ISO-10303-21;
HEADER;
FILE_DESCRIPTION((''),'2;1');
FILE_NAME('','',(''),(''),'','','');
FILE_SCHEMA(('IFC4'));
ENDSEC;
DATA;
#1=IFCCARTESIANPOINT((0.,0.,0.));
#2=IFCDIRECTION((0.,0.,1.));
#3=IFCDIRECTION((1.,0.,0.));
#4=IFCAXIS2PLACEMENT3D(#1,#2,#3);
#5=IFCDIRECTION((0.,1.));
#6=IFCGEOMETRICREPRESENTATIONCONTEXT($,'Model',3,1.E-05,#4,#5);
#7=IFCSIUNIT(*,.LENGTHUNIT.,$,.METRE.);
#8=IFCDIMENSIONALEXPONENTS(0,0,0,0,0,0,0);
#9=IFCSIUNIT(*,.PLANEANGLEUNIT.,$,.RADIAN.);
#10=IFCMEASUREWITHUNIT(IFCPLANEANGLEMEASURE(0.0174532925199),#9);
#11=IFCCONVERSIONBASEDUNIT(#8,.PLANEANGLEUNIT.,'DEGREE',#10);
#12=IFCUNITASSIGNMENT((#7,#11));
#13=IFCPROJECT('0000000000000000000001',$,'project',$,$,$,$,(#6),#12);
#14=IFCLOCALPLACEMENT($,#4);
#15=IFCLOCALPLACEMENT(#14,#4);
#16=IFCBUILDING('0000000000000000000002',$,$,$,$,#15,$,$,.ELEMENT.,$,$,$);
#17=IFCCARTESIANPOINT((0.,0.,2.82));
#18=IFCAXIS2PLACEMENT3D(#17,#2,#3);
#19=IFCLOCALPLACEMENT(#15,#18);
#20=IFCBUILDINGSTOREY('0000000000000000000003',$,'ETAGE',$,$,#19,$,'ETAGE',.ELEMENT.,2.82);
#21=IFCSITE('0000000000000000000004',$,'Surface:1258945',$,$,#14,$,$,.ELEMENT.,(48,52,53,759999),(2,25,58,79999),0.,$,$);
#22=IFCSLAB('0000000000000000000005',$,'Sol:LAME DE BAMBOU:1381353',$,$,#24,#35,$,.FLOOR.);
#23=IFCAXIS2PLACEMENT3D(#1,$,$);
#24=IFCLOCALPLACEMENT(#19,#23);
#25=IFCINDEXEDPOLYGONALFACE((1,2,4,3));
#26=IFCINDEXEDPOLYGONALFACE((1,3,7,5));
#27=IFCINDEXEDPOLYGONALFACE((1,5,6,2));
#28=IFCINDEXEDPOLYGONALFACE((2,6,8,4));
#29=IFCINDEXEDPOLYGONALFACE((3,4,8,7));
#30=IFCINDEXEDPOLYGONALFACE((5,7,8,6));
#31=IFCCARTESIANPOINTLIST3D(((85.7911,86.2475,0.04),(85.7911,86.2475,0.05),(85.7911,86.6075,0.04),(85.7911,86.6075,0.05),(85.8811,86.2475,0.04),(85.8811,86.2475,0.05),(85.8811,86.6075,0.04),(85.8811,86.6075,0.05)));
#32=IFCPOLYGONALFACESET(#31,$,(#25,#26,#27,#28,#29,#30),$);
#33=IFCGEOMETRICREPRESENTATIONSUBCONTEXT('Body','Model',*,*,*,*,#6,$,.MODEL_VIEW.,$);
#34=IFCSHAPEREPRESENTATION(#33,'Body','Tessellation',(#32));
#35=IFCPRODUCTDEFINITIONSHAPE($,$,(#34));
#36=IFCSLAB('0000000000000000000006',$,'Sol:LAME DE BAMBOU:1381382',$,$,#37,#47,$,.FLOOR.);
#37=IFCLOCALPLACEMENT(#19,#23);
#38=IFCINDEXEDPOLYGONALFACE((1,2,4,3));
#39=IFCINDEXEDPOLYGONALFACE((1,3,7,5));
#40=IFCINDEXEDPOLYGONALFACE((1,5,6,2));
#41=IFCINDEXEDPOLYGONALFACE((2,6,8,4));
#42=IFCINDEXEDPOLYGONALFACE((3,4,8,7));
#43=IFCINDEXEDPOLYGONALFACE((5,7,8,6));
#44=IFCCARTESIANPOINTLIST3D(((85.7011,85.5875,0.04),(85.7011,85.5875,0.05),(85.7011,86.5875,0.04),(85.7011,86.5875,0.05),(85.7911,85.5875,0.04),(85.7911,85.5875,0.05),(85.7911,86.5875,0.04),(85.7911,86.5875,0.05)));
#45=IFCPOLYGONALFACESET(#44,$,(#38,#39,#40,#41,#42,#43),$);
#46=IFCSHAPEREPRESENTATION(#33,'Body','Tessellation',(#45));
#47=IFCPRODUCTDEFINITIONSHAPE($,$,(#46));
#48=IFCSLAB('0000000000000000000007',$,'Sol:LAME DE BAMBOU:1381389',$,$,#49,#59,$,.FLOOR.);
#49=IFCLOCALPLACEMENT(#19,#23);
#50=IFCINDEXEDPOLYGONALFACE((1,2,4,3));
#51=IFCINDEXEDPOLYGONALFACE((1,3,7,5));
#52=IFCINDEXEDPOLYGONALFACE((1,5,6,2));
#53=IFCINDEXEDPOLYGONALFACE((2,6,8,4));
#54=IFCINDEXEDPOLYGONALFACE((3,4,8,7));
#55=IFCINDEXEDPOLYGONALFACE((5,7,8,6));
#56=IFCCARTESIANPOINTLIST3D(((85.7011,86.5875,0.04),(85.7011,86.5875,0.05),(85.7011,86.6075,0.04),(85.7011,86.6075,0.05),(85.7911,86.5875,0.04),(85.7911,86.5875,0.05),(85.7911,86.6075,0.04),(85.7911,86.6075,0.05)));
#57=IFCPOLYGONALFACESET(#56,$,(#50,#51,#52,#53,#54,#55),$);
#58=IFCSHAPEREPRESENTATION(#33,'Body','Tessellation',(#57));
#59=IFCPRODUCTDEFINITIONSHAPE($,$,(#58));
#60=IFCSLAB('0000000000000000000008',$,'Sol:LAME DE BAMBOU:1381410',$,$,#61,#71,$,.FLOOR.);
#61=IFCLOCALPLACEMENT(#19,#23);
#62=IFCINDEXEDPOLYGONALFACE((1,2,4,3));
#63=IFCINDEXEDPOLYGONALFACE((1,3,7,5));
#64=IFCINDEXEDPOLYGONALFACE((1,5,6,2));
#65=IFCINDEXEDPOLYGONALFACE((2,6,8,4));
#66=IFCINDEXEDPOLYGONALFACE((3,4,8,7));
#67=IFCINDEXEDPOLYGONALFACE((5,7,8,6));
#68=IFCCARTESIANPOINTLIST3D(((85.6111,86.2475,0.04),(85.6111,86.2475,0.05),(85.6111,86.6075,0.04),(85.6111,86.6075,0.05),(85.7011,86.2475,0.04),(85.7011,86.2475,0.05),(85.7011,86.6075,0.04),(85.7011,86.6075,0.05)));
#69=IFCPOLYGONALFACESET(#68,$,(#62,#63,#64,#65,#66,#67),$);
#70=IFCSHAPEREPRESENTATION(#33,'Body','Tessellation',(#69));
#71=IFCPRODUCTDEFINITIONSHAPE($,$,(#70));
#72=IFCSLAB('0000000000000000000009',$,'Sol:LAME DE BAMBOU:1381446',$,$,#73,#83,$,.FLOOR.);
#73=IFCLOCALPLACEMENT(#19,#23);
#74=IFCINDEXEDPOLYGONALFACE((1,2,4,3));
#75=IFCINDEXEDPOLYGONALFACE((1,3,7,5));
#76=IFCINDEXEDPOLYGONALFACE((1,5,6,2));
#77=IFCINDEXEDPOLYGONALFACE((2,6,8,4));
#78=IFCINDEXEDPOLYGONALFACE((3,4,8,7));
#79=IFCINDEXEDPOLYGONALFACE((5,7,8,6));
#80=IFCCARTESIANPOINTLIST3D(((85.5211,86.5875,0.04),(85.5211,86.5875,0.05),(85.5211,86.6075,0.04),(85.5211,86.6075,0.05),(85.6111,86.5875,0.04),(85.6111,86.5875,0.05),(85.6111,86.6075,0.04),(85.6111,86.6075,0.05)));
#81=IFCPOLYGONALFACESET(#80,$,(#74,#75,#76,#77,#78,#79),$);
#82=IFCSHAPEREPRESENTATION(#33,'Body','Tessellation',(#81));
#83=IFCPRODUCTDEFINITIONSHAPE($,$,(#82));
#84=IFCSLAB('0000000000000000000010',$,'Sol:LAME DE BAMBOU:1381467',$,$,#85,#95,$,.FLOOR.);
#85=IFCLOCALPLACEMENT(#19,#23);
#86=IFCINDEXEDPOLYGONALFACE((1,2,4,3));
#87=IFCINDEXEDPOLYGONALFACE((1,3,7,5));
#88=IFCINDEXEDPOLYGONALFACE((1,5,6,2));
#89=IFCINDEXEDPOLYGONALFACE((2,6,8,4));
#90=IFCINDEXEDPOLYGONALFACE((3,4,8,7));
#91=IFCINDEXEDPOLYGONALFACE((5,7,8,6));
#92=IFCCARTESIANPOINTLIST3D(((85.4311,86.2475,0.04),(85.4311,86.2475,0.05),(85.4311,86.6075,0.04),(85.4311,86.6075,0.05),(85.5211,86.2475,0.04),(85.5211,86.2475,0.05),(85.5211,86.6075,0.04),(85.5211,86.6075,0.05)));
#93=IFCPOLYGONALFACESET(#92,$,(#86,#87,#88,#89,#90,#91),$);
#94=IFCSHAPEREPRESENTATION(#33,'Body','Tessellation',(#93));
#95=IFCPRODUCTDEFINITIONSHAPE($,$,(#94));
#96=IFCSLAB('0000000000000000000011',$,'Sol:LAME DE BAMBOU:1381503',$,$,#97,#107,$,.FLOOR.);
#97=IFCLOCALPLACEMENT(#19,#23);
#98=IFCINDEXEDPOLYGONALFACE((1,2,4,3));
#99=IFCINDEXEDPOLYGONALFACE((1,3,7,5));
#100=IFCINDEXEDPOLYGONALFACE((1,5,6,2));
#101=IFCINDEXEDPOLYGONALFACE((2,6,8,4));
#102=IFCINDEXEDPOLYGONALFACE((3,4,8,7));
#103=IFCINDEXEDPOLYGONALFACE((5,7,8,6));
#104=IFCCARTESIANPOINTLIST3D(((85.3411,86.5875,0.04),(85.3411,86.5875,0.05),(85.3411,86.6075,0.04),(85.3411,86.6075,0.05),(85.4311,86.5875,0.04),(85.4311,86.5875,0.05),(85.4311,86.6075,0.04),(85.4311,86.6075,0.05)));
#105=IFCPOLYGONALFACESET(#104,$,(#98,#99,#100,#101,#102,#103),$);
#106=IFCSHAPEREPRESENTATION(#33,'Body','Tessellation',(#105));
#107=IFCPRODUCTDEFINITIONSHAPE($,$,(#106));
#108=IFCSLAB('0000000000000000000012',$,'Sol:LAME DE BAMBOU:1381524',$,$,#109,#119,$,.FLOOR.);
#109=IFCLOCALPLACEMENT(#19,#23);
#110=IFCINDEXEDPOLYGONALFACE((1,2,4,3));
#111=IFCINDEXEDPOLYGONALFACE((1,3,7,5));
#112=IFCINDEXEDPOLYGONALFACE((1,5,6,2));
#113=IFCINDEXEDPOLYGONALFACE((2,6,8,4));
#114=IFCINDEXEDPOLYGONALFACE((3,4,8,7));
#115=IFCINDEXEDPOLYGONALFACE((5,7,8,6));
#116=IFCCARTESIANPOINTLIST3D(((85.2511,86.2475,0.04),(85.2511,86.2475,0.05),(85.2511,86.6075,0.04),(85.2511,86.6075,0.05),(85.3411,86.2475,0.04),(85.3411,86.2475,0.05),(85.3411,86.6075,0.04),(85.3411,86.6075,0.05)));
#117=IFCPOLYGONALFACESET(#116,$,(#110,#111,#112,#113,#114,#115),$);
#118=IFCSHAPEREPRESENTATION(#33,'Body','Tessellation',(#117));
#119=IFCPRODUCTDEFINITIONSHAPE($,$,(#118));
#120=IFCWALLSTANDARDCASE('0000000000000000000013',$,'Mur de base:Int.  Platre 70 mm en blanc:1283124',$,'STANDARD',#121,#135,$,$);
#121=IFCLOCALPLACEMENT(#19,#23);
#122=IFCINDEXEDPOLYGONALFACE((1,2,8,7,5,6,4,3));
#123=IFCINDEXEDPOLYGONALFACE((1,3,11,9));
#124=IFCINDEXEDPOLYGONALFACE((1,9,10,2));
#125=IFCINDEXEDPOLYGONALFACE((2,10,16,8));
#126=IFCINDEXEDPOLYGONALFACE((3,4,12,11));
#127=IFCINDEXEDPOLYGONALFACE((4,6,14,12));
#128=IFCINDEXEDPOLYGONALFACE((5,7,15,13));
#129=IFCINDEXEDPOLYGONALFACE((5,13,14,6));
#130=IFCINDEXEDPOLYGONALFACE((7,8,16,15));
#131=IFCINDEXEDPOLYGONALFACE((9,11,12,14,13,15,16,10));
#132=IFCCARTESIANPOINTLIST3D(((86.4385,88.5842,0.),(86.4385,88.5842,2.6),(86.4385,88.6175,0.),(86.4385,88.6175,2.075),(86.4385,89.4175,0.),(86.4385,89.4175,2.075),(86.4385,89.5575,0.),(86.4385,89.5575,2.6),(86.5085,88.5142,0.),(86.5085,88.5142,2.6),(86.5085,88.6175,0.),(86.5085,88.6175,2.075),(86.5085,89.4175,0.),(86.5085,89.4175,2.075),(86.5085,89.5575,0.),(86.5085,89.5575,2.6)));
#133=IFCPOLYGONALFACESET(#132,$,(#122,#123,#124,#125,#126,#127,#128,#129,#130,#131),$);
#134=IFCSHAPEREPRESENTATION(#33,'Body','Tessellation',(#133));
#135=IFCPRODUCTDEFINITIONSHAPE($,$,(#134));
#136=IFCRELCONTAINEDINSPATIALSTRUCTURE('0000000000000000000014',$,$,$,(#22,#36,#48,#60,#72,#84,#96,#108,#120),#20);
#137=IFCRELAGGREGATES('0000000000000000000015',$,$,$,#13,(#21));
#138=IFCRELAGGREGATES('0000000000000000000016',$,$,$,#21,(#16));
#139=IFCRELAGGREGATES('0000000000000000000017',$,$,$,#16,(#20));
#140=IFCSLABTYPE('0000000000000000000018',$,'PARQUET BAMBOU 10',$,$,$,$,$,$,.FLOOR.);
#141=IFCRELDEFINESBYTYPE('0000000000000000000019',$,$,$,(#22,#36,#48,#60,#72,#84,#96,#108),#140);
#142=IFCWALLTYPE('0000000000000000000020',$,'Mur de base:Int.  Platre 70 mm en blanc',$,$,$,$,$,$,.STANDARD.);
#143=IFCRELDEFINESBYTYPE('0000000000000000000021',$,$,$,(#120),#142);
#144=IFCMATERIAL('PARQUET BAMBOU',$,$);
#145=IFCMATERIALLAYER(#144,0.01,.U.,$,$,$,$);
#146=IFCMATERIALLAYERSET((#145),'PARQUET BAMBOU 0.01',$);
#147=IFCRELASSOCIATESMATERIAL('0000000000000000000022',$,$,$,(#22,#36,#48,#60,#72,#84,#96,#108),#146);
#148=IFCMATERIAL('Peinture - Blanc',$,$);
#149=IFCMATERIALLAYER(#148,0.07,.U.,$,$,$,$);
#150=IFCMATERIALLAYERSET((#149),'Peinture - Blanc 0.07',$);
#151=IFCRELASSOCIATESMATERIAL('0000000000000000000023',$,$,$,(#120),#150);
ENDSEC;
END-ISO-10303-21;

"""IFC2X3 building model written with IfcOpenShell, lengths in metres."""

from ifc_helpers import new_model, entity, si_unit, converted_unit, direction, frame, origin_with_axes, place, context, subcontext, project, spatial, polyline, outline, extrude, material, layer, layer_set, layer_usage, type_object, element, save


model = new_model("IFC2X3")

# Units and contexts
model_context = context("Model", 3, precision=1e-05, world=origin_with_axes(), true_north=direction((0.0, 1.0)))
body_context = subcontext(model_context, "Body", "Model", "MODEL_VIEW")
ifc_project = project(units=[si_unit("LENGTHUNIT", "METRE"), converted_unit("PLANEANGLEUNIT", "DEGREE", entity("IfcPlaneAngleMeasure", 0.0174532925199), si_unit("PLANEANGLEUNIT", "RADIAN"), dimensions=[0, 0, 0, 0, 0, 0, 0])], contexts=[model_context])

# Site, building, storey
site_placement = place(None, origin_with_axes())
site = spatial("IfcSite", under=ifc_project, at=site_placement, Name="Surface:1258945", CompositionType="ELEMENT", RefLatitude=(48, 52, 53, 759999), RefLongitude=(2, 25, 58, 79999), RefElevation=0.0)
building_placement = place(site_placement, origin_with_axes())
building = spatial("IfcBuilding", under=site, at=building_placement, CompositionType="ELEMENT")
storey_placement = place(building_placement, frame((0.0, 0.0, 2.82), z_axis=(0.0, 0.0, 1.0), x_axis=(1.0, 0.0, 0.0)))
storey = spatial("IfcBuildingStorey", under=building, at=storey_placement, Name="ETAGE", LongName="ETAGE", CompositionType="ELEMENT", Elevation=2.82)

# Slabs
ifc_material_1 = material(Name="PARQUET BAMBOU")
ifc_layer_1 = layer(ifc_material_1, 0.01, ventilated="UNKNOWN")
ifc_layer_set_1 = layer_set([ifc_layer_1], Name="PARQUET BAMBOU 0.01")
slab_type = type_object("IfcSlabType", Name="PARQUET BAMBOU 10", PredefinedType="FLOOR")
ifc_layer_usage_1 = layer_usage(ifc_layer_set_1, "AXIS3", "NEGATIVE", 0.01)
slab_1_placement = place(storey_placement, frame((85.7911, 86.6075, 0.05), z_axis=(0.0, 0.0, 1.0), x_axis=(1.0, 0.0, 0.0)))
element("IfcSlab", 1, at=slab_1_placement, inside=storey, type_object=slab_type, material=ifc_layer_usage_1, Name="Sol:LAME DE BAMBOU:1381353", PredefinedType="FLOOR", context=body_context, shape_type="SweptSolid", body=[
    extrude(outline(polyline([(0.0, 0.0), (0.0, -0.36), (0.09, -0.36), (0.09, 0.0), (0.0, 0.0)])), frame((0.0, 0.0, -0.01), z_axis=(0.0, 0.0, 1.0), x_axis=(1.0, 0.0, 0.0)), (0.0, 0.0, 1.0), 0.01),
])
ifc_layer_usage_2 = layer_usage(ifc_layer_set_1, "AXIS3", "NEGATIVE", 0.01)
slab_2_placement = place(storey_placement, frame((85.7011, 86.5875, 0.05), z_axis=(0.0, 0.0, 1.0), x_axis=(1.0, 0.0, 0.0)))
element("IfcSlab", 2, at=slab_2_placement, inside=storey, type_object=slab_type, material=ifc_layer_usage_2, Name="Sol:LAME DE BAMBOU:1381382", PredefinedType="FLOOR", context=body_context, shape_type="SweptSolid", body=[
    extrude(outline(polyline([(0.0, 0.0), (0.0, -1.0), (0.09, -1.0), (0.09, 0.0), (0.0, 0.0)])), frame((0.0, 0.0, -0.01), z_axis=(0.0, 0.0, 1.0), x_axis=(1.0, 0.0, 0.0)), (0.0, 0.0, 1.0), 0.01),
])
ifc_layer_usage_3 = layer_usage(ifc_layer_set_1, "AXIS3", "NEGATIVE", 0.01)
slab_3_placement = place(storey_placement, frame((85.7011, 86.6075, 0.05), z_axis=(0.0, 0.0, 1.0), x_axis=(1.0, 0.0, 0.0)))
element("IfcSlab", 3, at=slab_3_placement, inside=storey, type_object=slab_type, material=ifc_layer_usage_3, Name="Sol:LAME DE BAMBOU:1381389", PredefinedType="FLOOR", context=body_context, shape_type="SweptSolid", body=[
    extrude(outline(polyline([(0.0, 0.0), (0.0, -0.02), (0.09, -0.02), (0.09, 0.0), (0.0, 0.0)])), frame((0.0, 0.0, -0.01), z_axis=(0.0, 0.0, 1.0), x_axis=(1.0, 0.0, 0.0)), (0.0, 0.0, 1.0), 0.01),
])
ifc_layer_usage_4 = layer_usage(ifc_layer_set_1, "AXIS3", "NEGATIVE", 0.01)
slab_4_placement = place(storey_placement, frame((85.6111, 86.6075, 0.05), z_axis=(0.0, 0.0, 1.0), x_axis=(1.0, 0.0, 0.0)))
element("IfcSlab", 4, at=slab_4_placement, inside=storey, type_object=slab_type, material=ifc_layer_usage_4, Name="Sol:LAME DE BAMBOU:1381410", PredefinedType="FLOOR", context=body_context, shape_type="SweptSolid", body=[
    extrude(outline(polyline([(0.0, 0.0), (0.0, -0.36), (0.09, -0.36), (0.09, 0.0), (0.0, 0.0)])), frame((0.0, 0.0, -0.01), z_axis=(0.0, 0.0, 1.0), x_axis=(1.0, 0.0, 0.0)), (0.0, 0.0, 1.0), 0.01),
])
ifc_layer_usage_5 = layer_usage(ifc_layer_set_1, "AXIS3", "NEGATIVE", 0.01)
slab_5_placement = place(storey_placement, frame((85.5211, 86.6075, 0.05), z_axis=(0.0, 0.0, 1.0), x_axis=(1.0, 0.0, 0.0)))
element("IfcSlab", 5, at=slab_5_placement, inside=storey, type_object=slab_type, material=ifc_layer_usage_5, Name="Sol:LAME DE BAMBOU:1381446", PredefinedType="FLOOR", context=body_context, shape_type="SweptSolid", body=[
    extrude(outline(polyline([(0.0, 0.0), (0.0, -0.02), (0.09, -0.02), (0.09, 0.0), (0.0, 0.0)])), frame((0.0, 0.0, -0.01), z_axis=(0.0, 0.0, 1.0), x_axis=(1.0, 0.0, 0.0)), (0.0, 0.0, 1.0), 0.01),
])
ifc_layer_usage_6 = layer_usage(ifc_layer_set_1, "AXIS3", "NEGATIVE", 0.01)
slab_6_placement = place(storey_placement, frame((85.4311, 86.6075, 0.05), z_axis=(0.0, 0.0, 1.0), x_axis=(1.0, 0.0, 0.0)))
element("IfcSlab", 6, at=slab_6_placement, inside=storey, type_object=slab_type, material=ifc_layer_usage_6, Name="Sol:LAME DE BAMBOU:1381467", PredefinedType="FLOOR", context=body_context, shape_type="SweptSolid", body=[
    extrude(outline(polyline([(0.0, 0.0), (0.0, -0.36), (0.09, -0.36), (0.09, 0.0), (0.0, 0.0)])), frame((0.0, 0.0, -0.01), z_axis=(0.0, 0.0, 1.0), x_axis=(1.0, 0.0, 0.0)), (0.0, 0.0, 1.0), 0.01),
])
ifc_layer_usage_7 = layer_usage(ifc_layer_set_1, "AXIS3", "NEGATIVE", 0.01)
slab_7_placement = place(storey_placement, frame((85.3411, 86.6075, 0.05), z_axis=(0.0, 0.0, 1.0), x_axis=(1.0, 0.0, 0.0)))
element("IfcSlab", 7, at=slab_7_placement, inside=storey, type_object=slab_type, material=ifc_layer_usage_7, Name="Sol:LAME DE BAMBOU:1381503", PredefinedType="FLOOR", context=body_context, shape_type="SweptSolid", body=[
    extrude(outline(polyline([(0.0, 0.0), (0.0, -0.02), (0.09, -0.02), (0.09, 0.0), (0.0, 0.0)])), frame((0.0, 0.0, -0.01), z_axis=(0.0, 0.0, 1.0), x_axis=(1.0, 0.0, 0.0)), (0.0, 0.0, 1.0), 0.01),
])
ifc_layer_usage_8 = layer_usage(ifc_layer_set_1, "AXIS3", "NEGATIVE", 0.01)
slab_8_placement = place(storey_placement, frame((85.2511, 86.6075, 0.05), z_axis=(0.0, 0.0, 1.0), x_axis=(1.0, 0.0, 0.0)))
element("IfcSlab", 8, at=slab_8_placement, inside=storey, type_object=slab_type, material=ifc_layer_usage_8, Name="Sol:LAME DE BAMBOU:1381524", PredefinedType="FLOOR", context=body_context, shape_type="SweptSolid", body=[
    extrude(outline(polyline([(0.0, 0.0), (0.0, -0.36), (0.09, -0.36), (0.09, 0.0), (0.0, 0.0)])), frame((0.0, 0.0, -0.01), z_axis=(0.0, 0.0, 1.0), x_axis=(1.0, 0.0, 0.0)), (0.0, 0.0, 1.0), 0.01),
])

# Wall, opening
ifc_material_2 = material(Name="Peinture - Blanc")
ifc_layer_2 = layer(ifc_material_2, 0.07, ventilated="UNKNOWN")
ifc_layer_set_2 = layer_set([ifc_layer_2], Name="Peinture - Blanc 0.07")
ifc_layer_usage_9 = layer_usage(ifc_layer_set_2, "AXIS2", "POSITIVE", -0.035)
wall_type = type_object("IfcWallType", Name="Mur de base:Int.  Platre 70 mm en blanc", PredefinedType="STANDARD")
wall_placement = place(storey_placement, frame((86.4735, 88.5492, 0.0), z_axis=(0.0, 0.0, 1.0), x_axis=(0.0, 1.0, 0.0)))
wall = element("IfcWallStandardCase", 9, at=wall_placement, inside=storey, type_object=wall_type, material=ifc_layer_usage_9, Name="Mur de base:Int.  Platre 70 mm en blanc:1283124", ObjectType="STANDARD", context=body_context, shape_type="SweptSolid", body=[
    extrude(outline(polyline([(-0.035, -0.035), (1.0083, -0.035), (1.0083, 0.035), (0.035, 0.035), (-0.035, -0.035)])), origin_with_axes(), (0.0, 0.0, 1.0), 2.6),
])
opening_placement = place(wall_placement, frame((0.4683, 0.0, 0.0), z_axis=(0.0, 0.0, 1.0), x_axis=(1.0, 0.0, 0.0)))
element("IfcOpeningElement", 10, at=opening_placement, cuts=wall, context=body_context, shape_type="SweptSolid", body=[
    extrude(outline(polyline([(-0.4, 0.0), (0.4, 0.0), (0.4, 2.075), (-0.4, 2.075), (-0.4, 0.0)])), frame((0.0, 0.035, 0.0), z_axis=(0.0, 1.0, 0.0), x_axis=(-1.0, 0.0, 0.0)), (0.0, 0.0, -1.0), 0.07),
])

save(model, "model.ifc")
